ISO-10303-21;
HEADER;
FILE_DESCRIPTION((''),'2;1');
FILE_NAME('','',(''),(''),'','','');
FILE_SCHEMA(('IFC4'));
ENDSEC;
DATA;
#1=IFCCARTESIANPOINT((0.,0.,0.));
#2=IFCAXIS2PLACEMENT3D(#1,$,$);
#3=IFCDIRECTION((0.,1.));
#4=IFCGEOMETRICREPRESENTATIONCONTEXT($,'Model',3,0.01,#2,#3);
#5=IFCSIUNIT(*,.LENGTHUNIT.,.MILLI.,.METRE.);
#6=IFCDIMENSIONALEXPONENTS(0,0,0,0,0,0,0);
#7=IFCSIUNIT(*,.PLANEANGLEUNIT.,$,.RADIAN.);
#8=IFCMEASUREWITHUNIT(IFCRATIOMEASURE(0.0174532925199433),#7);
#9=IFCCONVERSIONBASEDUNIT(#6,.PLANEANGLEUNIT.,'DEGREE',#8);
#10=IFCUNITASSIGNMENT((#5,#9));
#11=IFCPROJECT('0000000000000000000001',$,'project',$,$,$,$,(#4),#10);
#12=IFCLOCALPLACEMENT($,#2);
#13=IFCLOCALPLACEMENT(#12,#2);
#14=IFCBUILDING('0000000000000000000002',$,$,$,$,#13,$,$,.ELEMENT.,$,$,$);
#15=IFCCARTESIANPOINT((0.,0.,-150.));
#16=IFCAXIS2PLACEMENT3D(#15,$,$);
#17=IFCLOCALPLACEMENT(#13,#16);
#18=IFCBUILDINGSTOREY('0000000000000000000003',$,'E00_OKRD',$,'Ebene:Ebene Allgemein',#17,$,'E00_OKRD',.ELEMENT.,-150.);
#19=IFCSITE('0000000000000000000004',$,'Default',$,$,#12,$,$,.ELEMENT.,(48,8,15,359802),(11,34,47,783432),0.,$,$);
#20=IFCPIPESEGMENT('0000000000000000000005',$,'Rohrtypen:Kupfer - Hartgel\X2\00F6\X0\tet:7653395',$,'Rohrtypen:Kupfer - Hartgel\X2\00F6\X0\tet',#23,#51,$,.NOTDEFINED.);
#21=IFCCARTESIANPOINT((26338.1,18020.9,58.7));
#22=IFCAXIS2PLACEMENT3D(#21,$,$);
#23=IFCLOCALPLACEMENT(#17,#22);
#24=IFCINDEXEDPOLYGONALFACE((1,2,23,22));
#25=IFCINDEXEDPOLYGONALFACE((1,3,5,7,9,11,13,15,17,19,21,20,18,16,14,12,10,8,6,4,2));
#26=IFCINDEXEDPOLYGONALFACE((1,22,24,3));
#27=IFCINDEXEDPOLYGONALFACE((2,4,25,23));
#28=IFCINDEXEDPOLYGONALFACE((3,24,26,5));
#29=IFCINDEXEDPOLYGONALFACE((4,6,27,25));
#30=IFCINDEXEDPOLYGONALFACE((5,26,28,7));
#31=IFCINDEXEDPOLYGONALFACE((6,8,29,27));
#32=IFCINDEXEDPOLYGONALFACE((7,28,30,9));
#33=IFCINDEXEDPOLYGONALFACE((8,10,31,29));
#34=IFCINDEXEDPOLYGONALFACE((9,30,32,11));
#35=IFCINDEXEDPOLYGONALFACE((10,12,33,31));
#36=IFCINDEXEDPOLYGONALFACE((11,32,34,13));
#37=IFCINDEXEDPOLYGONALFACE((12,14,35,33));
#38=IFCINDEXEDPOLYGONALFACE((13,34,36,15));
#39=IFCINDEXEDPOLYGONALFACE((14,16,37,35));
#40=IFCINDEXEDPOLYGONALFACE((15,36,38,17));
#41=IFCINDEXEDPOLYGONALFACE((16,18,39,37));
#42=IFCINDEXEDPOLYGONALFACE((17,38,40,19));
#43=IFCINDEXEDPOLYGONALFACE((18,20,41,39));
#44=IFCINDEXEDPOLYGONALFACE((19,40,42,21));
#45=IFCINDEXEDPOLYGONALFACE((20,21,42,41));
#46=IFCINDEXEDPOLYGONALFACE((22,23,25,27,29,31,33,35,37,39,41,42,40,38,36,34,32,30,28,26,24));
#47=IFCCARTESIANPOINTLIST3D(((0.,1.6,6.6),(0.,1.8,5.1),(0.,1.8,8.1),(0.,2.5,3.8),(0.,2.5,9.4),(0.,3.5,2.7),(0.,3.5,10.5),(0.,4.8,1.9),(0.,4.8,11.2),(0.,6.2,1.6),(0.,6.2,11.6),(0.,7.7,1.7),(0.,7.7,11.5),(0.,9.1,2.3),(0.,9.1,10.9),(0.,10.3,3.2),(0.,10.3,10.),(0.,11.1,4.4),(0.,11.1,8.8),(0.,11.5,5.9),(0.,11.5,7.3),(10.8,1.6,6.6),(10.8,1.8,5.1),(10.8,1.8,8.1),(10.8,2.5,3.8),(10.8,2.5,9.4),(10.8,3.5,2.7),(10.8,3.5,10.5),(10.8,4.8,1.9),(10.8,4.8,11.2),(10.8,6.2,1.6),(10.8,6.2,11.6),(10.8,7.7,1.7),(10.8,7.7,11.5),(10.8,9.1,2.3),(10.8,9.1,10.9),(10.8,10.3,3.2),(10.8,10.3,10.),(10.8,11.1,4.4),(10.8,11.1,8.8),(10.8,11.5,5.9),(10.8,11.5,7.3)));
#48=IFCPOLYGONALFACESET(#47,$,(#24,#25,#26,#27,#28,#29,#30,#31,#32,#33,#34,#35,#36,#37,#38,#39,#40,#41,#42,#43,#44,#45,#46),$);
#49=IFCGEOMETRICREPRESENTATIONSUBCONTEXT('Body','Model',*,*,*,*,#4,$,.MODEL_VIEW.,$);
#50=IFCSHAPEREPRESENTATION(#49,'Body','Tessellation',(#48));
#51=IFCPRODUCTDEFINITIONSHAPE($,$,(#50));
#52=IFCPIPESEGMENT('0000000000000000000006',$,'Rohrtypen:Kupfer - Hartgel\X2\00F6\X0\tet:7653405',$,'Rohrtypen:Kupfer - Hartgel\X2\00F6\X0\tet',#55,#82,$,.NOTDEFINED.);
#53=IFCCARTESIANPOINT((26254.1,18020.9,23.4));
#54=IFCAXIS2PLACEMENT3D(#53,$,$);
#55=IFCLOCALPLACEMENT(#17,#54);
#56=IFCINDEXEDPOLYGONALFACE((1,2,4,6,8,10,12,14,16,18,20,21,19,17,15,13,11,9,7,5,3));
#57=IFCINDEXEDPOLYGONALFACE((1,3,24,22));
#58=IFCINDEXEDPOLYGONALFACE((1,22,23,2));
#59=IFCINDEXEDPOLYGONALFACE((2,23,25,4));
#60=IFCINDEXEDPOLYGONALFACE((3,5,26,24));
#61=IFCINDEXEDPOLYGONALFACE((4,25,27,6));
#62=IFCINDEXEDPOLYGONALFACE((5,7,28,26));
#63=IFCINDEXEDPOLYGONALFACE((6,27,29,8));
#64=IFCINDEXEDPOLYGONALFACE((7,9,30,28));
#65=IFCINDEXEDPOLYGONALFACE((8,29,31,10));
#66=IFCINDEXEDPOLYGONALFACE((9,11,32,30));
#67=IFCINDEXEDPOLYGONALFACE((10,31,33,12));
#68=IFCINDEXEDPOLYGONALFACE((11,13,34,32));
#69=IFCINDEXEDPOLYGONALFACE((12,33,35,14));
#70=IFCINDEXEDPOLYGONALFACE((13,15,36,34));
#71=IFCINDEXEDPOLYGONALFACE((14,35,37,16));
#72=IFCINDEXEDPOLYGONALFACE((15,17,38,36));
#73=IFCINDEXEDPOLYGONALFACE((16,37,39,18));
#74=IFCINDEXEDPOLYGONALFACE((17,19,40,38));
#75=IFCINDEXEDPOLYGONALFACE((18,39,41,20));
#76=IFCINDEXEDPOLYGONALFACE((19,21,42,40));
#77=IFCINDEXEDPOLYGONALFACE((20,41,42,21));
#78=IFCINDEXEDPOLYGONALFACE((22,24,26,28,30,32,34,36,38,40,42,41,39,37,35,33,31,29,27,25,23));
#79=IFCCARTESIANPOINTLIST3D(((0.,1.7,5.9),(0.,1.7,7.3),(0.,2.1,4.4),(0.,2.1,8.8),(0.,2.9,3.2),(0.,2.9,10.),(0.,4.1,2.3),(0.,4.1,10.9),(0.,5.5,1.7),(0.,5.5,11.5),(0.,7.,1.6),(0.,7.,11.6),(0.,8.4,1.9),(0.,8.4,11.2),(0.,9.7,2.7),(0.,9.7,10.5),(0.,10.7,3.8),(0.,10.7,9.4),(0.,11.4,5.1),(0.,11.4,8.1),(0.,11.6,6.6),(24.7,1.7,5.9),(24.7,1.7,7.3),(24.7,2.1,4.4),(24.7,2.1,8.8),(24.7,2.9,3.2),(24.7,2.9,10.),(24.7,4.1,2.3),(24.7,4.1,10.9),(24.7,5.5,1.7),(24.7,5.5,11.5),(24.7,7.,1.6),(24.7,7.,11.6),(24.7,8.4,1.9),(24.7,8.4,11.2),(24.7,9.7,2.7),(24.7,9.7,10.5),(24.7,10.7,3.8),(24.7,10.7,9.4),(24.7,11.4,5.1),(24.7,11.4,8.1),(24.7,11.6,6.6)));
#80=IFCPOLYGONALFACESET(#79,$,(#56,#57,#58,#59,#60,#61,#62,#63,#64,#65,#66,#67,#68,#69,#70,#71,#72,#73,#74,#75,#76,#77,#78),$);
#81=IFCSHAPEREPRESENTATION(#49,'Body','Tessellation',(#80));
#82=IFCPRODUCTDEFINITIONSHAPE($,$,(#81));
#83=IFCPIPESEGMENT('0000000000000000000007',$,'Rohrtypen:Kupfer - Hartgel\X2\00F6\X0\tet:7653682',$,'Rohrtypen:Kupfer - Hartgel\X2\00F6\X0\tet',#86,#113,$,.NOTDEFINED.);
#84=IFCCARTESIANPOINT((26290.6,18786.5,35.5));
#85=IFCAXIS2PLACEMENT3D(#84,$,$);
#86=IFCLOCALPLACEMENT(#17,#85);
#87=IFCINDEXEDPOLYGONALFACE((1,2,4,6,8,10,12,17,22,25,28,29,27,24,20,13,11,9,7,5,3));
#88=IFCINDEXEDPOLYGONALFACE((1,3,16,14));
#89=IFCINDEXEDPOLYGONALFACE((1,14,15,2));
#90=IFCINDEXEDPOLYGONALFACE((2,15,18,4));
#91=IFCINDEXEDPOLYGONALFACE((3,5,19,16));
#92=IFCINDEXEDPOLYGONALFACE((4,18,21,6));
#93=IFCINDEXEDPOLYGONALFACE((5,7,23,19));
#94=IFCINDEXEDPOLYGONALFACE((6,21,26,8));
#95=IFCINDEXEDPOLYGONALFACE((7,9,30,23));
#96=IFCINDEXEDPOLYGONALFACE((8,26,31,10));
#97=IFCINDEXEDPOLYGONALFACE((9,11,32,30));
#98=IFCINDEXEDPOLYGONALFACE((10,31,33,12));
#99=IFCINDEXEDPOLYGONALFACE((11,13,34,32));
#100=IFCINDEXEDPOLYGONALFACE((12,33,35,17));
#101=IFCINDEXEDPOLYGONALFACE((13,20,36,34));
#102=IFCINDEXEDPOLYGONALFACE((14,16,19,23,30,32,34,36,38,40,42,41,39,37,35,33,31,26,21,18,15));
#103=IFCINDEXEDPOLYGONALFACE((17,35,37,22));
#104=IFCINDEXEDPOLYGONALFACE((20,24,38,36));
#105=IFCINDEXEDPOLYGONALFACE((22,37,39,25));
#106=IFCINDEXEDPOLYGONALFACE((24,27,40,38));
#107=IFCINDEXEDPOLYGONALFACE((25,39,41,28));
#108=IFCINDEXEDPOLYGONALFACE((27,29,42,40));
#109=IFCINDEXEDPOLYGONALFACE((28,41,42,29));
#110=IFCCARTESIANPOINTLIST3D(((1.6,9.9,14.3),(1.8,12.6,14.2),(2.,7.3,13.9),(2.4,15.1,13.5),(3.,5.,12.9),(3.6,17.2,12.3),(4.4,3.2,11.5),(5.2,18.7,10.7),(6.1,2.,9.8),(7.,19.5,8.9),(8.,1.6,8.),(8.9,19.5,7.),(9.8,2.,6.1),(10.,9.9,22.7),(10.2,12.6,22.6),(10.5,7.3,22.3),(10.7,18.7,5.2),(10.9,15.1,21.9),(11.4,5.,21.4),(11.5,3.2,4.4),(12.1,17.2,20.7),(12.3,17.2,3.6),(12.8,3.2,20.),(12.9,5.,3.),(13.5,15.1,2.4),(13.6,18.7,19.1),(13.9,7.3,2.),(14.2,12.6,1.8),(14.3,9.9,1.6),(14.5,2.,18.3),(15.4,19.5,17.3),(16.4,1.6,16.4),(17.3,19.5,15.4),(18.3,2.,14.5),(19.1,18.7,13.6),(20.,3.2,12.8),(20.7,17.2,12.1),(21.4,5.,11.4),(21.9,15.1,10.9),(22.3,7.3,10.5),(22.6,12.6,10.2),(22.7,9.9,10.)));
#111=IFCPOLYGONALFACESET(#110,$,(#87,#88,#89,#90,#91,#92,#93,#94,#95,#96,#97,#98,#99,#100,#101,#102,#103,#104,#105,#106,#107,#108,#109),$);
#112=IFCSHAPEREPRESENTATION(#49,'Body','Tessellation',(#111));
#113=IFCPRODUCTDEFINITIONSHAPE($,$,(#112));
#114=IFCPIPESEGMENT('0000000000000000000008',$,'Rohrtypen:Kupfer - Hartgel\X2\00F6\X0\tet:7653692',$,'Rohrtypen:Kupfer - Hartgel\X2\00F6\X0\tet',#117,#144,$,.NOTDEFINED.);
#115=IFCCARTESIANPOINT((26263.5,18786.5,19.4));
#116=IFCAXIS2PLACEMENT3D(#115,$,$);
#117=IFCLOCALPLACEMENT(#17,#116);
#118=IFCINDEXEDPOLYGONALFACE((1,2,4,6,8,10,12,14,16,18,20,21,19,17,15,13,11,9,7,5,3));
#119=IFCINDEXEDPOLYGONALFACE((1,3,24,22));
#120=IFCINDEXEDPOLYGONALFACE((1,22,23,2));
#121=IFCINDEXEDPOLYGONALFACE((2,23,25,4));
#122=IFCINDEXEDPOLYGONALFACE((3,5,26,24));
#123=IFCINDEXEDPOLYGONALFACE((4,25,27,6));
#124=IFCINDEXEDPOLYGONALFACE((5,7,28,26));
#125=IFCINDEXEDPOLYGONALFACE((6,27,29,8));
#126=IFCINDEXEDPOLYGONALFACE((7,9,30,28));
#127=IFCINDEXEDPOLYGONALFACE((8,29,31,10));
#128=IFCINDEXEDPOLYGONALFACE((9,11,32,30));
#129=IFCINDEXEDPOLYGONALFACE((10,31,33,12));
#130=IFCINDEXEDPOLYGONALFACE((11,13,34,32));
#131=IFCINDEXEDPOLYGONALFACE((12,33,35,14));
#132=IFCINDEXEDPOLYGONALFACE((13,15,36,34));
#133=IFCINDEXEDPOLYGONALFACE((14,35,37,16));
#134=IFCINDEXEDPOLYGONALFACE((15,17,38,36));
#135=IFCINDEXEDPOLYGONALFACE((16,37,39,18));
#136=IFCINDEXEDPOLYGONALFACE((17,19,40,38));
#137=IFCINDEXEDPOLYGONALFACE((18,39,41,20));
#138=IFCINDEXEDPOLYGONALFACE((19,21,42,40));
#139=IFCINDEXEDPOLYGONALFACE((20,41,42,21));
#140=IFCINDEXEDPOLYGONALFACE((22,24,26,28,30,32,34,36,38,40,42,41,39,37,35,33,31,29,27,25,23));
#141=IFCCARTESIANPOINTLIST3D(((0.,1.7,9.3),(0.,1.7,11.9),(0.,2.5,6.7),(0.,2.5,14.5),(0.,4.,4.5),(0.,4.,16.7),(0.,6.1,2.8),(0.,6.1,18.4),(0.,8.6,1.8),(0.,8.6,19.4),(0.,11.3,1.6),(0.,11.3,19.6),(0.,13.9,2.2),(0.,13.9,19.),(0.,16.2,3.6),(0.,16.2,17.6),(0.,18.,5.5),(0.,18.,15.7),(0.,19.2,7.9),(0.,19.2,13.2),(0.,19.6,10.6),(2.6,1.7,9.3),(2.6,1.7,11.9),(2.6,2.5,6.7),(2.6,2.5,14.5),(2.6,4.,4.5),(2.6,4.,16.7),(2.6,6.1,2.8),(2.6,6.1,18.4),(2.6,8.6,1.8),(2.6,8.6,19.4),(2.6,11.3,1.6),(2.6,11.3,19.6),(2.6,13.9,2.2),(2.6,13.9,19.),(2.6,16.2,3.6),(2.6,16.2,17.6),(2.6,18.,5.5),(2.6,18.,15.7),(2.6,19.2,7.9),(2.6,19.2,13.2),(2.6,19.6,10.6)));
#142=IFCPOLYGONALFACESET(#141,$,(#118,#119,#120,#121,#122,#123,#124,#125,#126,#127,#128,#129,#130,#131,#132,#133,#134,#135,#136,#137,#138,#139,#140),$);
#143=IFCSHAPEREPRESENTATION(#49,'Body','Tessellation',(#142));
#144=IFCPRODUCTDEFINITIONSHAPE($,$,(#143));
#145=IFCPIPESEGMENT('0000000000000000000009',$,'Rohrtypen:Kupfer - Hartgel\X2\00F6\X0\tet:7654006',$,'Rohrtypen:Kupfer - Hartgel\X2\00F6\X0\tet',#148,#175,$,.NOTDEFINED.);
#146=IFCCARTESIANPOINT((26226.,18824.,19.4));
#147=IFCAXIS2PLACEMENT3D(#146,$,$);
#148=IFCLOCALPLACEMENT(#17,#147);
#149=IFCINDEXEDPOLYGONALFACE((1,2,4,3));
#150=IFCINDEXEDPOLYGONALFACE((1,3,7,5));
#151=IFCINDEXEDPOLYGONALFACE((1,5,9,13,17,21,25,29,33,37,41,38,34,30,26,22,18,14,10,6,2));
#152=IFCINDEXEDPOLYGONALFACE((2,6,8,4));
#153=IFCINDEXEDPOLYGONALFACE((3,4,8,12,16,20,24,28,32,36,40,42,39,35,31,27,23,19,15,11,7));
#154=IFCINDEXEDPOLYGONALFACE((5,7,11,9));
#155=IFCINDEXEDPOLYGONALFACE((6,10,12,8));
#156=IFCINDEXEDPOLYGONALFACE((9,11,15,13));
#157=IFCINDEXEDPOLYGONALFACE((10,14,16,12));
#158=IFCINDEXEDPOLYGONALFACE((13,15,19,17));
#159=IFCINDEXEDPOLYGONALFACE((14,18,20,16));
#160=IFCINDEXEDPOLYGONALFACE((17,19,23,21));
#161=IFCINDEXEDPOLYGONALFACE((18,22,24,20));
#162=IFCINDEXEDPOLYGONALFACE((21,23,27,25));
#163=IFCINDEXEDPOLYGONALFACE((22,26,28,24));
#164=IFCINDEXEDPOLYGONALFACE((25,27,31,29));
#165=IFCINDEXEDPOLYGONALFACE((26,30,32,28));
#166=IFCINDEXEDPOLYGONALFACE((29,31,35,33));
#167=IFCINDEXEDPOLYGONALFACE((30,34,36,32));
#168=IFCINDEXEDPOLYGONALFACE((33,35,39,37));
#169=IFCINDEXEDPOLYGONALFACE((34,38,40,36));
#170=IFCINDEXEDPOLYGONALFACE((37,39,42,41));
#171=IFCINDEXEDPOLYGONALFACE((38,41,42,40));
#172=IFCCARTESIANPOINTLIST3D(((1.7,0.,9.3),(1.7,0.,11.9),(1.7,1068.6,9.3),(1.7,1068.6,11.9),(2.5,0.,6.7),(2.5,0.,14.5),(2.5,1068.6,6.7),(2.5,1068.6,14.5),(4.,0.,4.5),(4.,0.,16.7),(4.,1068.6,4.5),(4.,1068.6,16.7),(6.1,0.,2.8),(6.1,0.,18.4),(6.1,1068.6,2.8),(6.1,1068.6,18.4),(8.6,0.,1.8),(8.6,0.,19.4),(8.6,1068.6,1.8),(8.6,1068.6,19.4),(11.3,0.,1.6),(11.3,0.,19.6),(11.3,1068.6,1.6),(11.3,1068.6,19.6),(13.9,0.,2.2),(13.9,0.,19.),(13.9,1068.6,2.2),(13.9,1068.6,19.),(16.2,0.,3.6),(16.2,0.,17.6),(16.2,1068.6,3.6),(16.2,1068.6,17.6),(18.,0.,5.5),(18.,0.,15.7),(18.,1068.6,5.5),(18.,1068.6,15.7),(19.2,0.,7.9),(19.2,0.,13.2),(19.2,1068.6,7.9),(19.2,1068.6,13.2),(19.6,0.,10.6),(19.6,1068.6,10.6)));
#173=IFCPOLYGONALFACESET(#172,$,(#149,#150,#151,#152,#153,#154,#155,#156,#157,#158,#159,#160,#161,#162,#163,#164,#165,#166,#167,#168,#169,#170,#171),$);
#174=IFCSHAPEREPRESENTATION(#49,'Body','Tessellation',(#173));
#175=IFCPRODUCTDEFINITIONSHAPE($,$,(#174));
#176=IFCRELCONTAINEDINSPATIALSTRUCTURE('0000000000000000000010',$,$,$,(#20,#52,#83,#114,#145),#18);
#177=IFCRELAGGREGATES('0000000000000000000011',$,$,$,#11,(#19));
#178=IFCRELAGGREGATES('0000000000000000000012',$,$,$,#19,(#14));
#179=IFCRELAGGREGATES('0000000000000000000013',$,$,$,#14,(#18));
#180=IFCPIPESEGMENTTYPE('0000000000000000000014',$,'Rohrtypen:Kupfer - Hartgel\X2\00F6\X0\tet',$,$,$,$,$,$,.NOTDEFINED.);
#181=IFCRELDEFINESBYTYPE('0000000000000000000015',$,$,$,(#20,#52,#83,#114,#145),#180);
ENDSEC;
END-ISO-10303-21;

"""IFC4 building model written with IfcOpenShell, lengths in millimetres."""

from ifc_helpers import new_model, entity, si_unit, converted_unit, direction, frame, frame_2d, origin, origin_2d_with_axis, place, context, subcontext, project, spatial, circle, extrude, type_object, element, save


model = new_model("IFC4")

# Units and contexts
model_context = context("Model", 3, precision=0.01, world=origin(), true_north=direction((0.0, 1.0)))
body_context = subcontext(model_context, "Body", "Model", "MODEL_VIEW")
ifc_project = project(units=[si_unit("LENGTHUNIT", "METRE", prefix="MILLI"), converted_unit("PLANEANGLEUNIT", "DEGREE", entity("IfcRatioMeasure", 0.0174532925199433), si_unit("PLANEANGLEUNIT", "RADIAN"), dimensions=[0, 0, 0, 0, 0, 0, 0])], contexts=[model_context])

# Site, building, storey
site_placement = place(None, origin())
site = spatial("IfcSite", under=ifc_project, at=site_placement, Name="Default", CompositionType="ELEMENT", RefLatitude=(48, 8, 15, 359802), RefLongitude=(11, 34, 47, 783432), RefElevation=0.0)
building_placement = place(site_placement, origin())
building = spatial("IfcBuilding", under=site, at=building_placement, CompositionType="ELEMENT")
storey_placement = place(building_placement, frame((0.0, 0.0, -150.0)))
storey = spatial("IfcBuildingStorey", under=building, at=storey_placement, Name="E00_OKRD", ObjectType="Ebene:Ebene Allgemein", LongName="E00_OKRD", CompositionType="ELEMENT", Elevation=-150.0)

# Pipe segments
pipe_segment_type = type_object("IfcPipeSegmentType", Name="Rohrtypen:Kupfer - Hartgelötet", PredefinedType="NOTDEFINED")
pipe_segment_1_placement = place(storey_placement, frame((26338.1, 18020.9, 58.7)))
element("IfcPipeSegment", 1, at=pipe_segment_1_placement, inside=storey, type_object=pipe_segment_type, Name="Rohrtypen:Kupfer - Hartgelötet:7653395", ObjectType="Rohrtypen:Kupfer - Hartgelötet", PredefinedType="NOTDEFINED", context=body_context, shape_type="SweptSolid", body=[
    extrude(circle(Radius=5.0, at=frame_2d((0.0, 0.0), x_axis=(1.0, 0.0))), frame((0.0, 6.6, 6.6), z_axis=(1.0, 0.0, 0.0), x_axis=(0.0, -1.0, 0.0)), (0.0, 0.0, 1.0), 10.8),
])
pipe_segment_2_placement = place(storey_placement, frame((26254.1, 18020.9, 23.4)))
element("IfcPipeSegment", 2, at=pipe_segment_2_placement, inside=storey, type_object=pipe_segment_type, Name="Rohrtypen:Kupfer - Hartgelötet:7653405", ObjectType="Rohrtypen:Kupfer - Hartgelötet", PredefinedType="NOTDEFINED", context=body_context, shape_type="SweptSolid", body=[
    extrude(circle(Radius=5.0, at=frame_2d((0.0, 0.0), x_axis=(1.0, 0.0))), frame((0.0, 6.6, 6.6), z_axis=(1.0, 0.0, 0.0), x_axis=(0.0, 1.0, 0.0)), (0.0, 0.0, 1.0), 24.7),
])
pipe_segment_3_placement = place(storey_placement, frame((26290.6, 18786.5, 35.5)))
element("IfcPipeSegment", 3, at=pipe_segment_3_placement, inside=storey, type_object=pipe_segment_type, Name="Rohrtypen:Kupfer - Hartgelötet:7653682", ObjectType="Rohrtypen:Kupfer - Hartgelötet", PredefinedType="NOTDEFINED", context=body_context, shape_type="SweptSolid", body=[
    extrude(circle(Radius=9.0, at=origin_2d_with_axis()), frame((8.0, 10.6, 8.0), z_axis=(0.707107, 0.0, 0.707107), x_axis=(0.0, -1.0, 0.0)), (0.0, 0.0, 1.0), 11.9),
])
pipe_segment_4_placement = place(storey_placement, frame((26263.5, 18786.5, 19.4)))
element("IfcPipeSegment", 4, at=pipe_segment_4_placement, inside=storey, type_object=pipe_segment_type, Name="Rohrtypen:Kupfer - Hartgelötet:7653692", ObjectType="Rohrtypen:Kupfer - Hartgelötet", PredefinedType="NOTDEFINED", context=body_context, shape_type="SweptSolid", body=[
    extrude(circle(Radius=9.0, at=frame_2d((0.0, 0.0), x_axis=(1.0, 0.0))), frame((0.0, 10.6, 10.6), z_axis=(1.0, 0.0, 0.0), x_axis=(0.0, 1.0, 0.0)), (0.0, 0.0, 1.0), 2.6),
])
pipe_segment_5_placement = place(storey_placement, frame((26226.0, 18824.0, 19.4)))
element("IfcPipeSegment", 5, at=pipe_segment_5_placement, inside=storey, type_object=pipe_segment_type, Name="Rohrtypen:Kupfer - Hartgelötet:7654006", ObjectType="Rohrtypen:Kupfer - Hartgelötet", PredefinedType="NOTDEFINED", context=body_context, shape_type="SweptSolid", body=[
    extrude(circle(Radius=9.0, at=origin_2d_with_axis()), frame((10.6, 0.0, 10.6), z_axis=(0.0, 1.0, 0.0), x_axis=(1.0, 0.0, 0.0)), (0.0, 0.0, 1.0), 1068.6),
])

save(model, "model.ifc")
